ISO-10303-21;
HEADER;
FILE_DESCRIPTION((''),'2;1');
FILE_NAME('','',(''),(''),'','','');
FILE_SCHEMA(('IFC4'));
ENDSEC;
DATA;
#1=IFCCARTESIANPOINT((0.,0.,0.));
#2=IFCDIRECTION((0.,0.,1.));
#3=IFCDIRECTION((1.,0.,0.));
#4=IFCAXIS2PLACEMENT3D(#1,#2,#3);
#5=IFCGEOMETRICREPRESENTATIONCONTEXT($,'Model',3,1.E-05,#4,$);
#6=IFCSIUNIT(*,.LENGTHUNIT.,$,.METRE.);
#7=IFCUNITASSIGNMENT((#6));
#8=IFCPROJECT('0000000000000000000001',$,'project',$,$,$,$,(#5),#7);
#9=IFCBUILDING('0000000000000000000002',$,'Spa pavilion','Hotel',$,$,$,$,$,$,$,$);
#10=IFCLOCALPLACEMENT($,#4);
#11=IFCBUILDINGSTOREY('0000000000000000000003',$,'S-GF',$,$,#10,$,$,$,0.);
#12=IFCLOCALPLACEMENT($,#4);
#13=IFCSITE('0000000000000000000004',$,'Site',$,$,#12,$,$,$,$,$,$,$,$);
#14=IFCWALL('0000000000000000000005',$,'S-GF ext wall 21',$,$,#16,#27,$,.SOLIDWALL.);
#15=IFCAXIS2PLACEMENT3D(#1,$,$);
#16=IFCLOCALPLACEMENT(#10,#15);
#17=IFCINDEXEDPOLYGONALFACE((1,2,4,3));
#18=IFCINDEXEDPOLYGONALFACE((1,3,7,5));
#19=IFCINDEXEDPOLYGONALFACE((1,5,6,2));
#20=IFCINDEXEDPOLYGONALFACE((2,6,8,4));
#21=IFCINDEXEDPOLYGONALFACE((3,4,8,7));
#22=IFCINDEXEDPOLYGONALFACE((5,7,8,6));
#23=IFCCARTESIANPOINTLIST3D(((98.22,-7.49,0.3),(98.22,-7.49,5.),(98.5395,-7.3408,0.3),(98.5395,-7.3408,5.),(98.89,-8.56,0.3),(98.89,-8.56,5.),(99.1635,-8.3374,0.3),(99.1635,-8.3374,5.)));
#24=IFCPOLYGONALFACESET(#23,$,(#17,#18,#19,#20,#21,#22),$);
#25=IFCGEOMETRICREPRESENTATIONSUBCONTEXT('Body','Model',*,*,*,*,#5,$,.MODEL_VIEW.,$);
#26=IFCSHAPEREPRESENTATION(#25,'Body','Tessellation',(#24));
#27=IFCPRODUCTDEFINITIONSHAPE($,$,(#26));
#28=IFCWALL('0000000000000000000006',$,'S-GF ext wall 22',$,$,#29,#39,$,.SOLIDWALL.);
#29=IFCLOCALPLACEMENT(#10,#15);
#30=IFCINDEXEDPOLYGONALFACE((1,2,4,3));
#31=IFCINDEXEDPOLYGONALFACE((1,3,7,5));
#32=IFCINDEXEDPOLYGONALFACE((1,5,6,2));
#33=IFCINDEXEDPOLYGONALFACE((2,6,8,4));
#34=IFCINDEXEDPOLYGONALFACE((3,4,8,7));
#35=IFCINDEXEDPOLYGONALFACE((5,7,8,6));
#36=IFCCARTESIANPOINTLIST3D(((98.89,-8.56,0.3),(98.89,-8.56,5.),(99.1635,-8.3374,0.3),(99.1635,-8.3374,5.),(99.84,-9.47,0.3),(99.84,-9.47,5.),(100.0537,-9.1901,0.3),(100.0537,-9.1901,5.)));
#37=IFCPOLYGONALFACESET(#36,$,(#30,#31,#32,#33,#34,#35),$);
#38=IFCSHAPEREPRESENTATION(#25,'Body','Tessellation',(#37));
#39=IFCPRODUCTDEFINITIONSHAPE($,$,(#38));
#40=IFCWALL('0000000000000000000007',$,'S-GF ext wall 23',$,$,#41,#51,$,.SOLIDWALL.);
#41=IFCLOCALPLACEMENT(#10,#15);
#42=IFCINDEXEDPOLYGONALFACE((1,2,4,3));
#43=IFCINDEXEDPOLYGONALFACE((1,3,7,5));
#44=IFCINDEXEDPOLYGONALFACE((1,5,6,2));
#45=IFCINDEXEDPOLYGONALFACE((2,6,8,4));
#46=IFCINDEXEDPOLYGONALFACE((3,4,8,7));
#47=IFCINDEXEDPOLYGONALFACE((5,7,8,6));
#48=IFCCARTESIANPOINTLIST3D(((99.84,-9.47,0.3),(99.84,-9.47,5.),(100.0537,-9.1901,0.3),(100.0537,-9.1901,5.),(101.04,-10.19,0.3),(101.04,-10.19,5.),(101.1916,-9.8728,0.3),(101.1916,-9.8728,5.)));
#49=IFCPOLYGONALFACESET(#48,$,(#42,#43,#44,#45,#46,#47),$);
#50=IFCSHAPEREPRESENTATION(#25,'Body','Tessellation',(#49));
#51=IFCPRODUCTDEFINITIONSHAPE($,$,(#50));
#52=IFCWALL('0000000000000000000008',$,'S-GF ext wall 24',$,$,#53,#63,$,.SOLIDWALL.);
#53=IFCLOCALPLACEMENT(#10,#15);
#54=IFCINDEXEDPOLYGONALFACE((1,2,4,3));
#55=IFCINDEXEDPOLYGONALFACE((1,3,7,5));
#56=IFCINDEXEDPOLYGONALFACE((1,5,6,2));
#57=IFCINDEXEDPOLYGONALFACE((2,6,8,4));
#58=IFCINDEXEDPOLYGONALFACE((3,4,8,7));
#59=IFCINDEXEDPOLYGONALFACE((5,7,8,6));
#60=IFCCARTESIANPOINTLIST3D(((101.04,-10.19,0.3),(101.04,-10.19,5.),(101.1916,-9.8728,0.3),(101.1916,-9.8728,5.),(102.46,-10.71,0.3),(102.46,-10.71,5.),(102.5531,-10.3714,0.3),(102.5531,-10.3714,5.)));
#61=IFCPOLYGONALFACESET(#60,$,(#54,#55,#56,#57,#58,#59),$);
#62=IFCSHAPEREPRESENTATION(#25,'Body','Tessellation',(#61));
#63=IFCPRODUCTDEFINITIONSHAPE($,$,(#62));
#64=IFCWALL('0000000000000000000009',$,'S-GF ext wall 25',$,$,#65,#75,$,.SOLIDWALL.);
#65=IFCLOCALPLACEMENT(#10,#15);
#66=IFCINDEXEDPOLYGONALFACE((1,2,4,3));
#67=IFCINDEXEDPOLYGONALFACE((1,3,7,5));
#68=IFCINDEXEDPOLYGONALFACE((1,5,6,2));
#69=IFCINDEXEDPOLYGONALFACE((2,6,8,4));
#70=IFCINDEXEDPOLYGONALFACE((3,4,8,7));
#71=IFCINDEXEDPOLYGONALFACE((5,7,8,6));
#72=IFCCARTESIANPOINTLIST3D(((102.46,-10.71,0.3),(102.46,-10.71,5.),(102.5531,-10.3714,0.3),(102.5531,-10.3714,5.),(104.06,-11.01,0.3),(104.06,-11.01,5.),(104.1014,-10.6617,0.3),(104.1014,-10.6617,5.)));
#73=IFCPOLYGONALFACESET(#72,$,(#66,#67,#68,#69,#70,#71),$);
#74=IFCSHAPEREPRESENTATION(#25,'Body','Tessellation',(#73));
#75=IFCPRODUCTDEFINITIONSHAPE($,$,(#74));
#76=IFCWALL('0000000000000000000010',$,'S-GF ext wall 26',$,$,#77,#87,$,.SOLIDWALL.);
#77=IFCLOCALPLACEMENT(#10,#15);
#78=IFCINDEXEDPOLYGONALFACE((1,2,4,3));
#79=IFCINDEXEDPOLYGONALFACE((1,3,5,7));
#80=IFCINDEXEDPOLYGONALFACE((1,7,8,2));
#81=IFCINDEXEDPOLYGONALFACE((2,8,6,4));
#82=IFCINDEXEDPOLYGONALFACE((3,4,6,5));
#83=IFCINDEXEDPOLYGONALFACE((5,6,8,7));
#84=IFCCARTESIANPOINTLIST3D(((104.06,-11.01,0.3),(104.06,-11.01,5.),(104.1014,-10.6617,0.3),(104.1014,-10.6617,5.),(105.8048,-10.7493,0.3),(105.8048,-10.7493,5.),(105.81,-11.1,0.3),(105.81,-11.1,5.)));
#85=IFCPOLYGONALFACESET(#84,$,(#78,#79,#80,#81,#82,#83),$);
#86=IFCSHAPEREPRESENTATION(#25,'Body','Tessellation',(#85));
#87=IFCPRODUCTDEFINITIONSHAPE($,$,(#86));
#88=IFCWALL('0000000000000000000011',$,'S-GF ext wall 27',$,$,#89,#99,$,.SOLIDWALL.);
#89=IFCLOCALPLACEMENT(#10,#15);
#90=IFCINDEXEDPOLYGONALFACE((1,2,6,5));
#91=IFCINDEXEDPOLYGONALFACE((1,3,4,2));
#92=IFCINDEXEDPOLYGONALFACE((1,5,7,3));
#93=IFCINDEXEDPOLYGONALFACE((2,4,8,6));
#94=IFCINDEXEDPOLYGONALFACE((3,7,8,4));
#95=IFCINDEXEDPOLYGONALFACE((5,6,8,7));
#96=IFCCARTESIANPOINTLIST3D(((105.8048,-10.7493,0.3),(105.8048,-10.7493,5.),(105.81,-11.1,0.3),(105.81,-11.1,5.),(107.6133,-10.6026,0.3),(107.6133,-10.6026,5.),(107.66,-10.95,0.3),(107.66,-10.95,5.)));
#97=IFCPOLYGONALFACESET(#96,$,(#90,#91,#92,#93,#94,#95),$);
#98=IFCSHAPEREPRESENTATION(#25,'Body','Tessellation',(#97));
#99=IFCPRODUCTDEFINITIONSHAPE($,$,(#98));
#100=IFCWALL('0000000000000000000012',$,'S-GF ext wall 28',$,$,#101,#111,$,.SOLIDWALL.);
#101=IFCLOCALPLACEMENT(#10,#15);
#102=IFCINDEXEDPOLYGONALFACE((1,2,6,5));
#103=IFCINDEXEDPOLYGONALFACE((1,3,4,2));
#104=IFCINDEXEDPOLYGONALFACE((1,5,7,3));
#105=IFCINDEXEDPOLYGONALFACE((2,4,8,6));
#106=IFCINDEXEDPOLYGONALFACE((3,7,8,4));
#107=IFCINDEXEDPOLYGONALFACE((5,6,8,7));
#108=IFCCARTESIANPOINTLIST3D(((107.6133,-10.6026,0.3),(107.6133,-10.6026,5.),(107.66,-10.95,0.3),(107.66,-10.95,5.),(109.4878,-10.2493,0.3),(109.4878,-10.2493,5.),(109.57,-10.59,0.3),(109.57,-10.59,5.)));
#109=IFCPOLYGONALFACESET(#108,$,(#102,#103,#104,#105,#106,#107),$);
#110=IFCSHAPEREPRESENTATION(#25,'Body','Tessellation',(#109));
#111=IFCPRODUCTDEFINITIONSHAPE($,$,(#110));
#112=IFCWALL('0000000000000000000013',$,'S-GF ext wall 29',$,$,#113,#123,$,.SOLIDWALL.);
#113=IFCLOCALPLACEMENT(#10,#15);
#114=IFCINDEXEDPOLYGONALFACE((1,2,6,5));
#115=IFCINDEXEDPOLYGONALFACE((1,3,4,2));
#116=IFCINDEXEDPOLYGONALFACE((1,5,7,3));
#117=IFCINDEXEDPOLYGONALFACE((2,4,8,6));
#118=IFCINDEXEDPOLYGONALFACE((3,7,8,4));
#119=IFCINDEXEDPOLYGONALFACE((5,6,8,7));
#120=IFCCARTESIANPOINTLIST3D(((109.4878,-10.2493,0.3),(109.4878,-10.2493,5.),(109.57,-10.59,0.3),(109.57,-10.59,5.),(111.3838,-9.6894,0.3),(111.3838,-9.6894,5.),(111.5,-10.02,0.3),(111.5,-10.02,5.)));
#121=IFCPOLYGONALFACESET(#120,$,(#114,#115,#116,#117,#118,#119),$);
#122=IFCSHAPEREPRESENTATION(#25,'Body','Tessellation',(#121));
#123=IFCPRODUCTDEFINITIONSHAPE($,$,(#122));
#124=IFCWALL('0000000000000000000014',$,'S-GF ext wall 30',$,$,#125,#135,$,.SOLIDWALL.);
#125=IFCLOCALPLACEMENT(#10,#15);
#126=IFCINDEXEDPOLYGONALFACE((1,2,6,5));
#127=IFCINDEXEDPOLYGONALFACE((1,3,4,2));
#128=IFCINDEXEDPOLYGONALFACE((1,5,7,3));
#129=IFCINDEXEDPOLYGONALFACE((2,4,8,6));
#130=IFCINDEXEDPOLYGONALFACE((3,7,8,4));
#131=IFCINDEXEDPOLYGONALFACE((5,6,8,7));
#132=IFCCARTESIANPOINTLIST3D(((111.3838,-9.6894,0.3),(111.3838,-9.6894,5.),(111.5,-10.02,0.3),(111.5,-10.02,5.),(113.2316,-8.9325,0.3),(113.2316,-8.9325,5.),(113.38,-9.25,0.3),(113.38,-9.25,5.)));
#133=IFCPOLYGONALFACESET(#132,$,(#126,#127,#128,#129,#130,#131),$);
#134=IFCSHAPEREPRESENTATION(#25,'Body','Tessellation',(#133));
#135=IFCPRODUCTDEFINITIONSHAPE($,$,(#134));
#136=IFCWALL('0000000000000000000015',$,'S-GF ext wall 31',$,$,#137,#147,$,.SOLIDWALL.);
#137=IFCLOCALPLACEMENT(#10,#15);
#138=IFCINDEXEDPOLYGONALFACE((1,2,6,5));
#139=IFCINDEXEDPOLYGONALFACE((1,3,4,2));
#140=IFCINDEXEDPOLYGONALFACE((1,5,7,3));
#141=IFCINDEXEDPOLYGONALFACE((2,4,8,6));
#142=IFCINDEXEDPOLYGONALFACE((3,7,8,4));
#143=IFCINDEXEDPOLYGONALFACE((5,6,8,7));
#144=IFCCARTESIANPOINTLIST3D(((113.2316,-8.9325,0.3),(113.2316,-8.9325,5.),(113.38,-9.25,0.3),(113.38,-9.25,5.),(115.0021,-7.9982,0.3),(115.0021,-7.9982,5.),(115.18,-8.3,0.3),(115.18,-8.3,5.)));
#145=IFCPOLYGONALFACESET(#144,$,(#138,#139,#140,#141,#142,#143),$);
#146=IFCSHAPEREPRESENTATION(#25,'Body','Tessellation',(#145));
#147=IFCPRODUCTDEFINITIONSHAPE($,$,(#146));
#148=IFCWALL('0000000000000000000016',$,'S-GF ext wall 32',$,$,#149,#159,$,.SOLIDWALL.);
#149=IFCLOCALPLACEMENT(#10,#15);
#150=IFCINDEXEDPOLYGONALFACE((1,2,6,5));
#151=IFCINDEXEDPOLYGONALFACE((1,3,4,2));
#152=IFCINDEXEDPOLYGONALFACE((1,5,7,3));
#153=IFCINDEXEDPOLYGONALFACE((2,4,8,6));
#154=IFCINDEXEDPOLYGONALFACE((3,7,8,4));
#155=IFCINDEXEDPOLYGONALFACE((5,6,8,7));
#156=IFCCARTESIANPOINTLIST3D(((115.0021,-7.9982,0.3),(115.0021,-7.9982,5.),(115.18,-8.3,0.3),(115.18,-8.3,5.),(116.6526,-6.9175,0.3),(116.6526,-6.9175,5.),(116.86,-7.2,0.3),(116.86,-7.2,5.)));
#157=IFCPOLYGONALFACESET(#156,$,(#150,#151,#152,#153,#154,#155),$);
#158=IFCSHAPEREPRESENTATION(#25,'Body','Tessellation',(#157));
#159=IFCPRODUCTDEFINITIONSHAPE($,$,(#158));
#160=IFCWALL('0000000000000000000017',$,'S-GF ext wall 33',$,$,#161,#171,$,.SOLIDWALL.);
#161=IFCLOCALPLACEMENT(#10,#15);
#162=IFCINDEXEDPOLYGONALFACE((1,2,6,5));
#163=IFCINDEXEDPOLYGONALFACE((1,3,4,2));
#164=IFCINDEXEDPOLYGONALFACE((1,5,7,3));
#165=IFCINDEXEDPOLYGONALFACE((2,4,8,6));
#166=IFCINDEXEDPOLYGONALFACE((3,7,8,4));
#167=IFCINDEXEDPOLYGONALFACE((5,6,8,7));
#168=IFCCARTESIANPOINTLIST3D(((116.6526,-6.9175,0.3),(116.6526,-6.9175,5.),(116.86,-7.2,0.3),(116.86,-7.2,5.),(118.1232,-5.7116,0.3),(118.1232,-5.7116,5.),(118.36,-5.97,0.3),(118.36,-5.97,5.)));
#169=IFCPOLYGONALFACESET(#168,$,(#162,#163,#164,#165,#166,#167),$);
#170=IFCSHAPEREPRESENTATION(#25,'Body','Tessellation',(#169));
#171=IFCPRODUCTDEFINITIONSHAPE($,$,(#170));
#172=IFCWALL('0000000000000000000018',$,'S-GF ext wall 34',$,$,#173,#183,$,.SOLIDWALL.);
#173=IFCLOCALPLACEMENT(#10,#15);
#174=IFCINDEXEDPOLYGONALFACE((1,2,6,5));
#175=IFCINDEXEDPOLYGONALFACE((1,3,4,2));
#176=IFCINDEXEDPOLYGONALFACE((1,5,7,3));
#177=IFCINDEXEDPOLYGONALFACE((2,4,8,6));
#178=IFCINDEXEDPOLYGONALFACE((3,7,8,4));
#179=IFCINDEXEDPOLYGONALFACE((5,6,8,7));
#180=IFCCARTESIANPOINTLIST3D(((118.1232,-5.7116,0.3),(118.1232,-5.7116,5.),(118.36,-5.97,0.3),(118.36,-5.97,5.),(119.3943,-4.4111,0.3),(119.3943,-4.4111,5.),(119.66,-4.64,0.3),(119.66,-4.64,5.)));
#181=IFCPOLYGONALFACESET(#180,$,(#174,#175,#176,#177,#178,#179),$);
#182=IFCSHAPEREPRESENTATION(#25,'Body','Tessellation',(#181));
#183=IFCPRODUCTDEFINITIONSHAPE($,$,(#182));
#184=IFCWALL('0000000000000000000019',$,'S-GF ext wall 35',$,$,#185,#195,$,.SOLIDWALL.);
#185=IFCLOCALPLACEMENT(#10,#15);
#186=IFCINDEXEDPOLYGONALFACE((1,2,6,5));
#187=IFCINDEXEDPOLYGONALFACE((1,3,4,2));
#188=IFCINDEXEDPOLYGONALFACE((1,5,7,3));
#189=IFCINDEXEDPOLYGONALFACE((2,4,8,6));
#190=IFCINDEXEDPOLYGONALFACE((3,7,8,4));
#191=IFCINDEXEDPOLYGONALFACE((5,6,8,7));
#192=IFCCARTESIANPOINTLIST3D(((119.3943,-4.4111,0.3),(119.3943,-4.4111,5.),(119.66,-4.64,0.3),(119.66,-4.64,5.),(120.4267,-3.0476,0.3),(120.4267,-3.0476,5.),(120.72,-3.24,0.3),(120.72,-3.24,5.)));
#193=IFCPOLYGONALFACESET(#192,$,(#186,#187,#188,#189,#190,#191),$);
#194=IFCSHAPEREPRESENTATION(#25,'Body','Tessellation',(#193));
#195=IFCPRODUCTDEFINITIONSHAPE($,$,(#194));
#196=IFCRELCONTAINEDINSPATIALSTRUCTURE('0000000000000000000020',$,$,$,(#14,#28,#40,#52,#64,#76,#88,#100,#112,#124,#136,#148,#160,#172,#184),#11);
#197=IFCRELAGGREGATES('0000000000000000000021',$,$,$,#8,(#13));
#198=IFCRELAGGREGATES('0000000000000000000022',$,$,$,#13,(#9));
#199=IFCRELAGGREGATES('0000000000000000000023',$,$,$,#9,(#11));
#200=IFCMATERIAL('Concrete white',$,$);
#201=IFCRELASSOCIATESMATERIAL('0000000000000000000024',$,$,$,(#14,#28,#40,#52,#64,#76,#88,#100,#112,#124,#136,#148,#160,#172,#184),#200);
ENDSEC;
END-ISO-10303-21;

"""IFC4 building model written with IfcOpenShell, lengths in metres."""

from ifc_helpers import new_model, si_unit, frame, origin_with_axes, place, context, subcontext, project, spatial, polyline, outline, extrude, material, element, save


model = new_model("IFC4")

# Units and contexts
model_context = context("Model", 3, precision=1e-05, world=origin_with_axes())
body_context = subcontext(model_context, "Body", "Model", "MODEL_VIEW")
ifc_project = project(units=[si_unit("LENGTHUNIT", "METRE")], contexts=[model_context])

# Site, building, storey
site_placement = place(None, origin_with_axes())
site = spatial("IfcSite", under=ifc_project, at=site_placement, Name="Site")
building = spatial("IfcBuilding", under=site, Name="Spa pavilion", Description="Hotel")
storey_placement = place(None, origin_with_axes())
storey = spatial("IfcBuildingStorey", under=building, at=storey_placement, Name="S-GF", Elevation=0.0)

# Walls
ifc_material_1 = material(Name="Concrete white")
wall_1_placement = place(storey_placement, origin_with_axes())
element("IfcWall", 1, at=wall_1_placement, inside=storey, material=ifc_material_1, Name="S-GF ext wall 21", PredefinedType="SOLIDWALL", context=body_context, shape_type="SweptSolid", body=[
    extrude(outline(polyline([(98.22, -7.49), (98.89, -8.56), (99.1635, -8.3374), (98.5395, -7.3408), (98.22, -7.49)])), frame((0.0, 0.0, 0.3), z_axis=(0.0, 0.0, 1.0), x_axis=(1.0, 0.0, 0.0)), (0.0, 0.0, 1.0), 4.7),
])
wall_2_placement = place(storey_placement, origin_with_axes())
element("IfcWall", 2, at=wall_2_placement, inside=storey, material=ifc_material_1, Name="S-GF ext wall 22", PredefinedType="SOLIDWALL", context=body_context, shape_type="SweptSolid", body=[
    extrude(outline(polyline([(98.89, -8.56), (99.84, -9.47), (100.0537, -9.1901), (99.1635, -8.3374), (98.89, -8.56)])), frame((0.0, 0.0, 0.3), z_axis=(0.0, 0.0, 1.0), x_axis=(1.0, 0.0, 0.0)), (0.0, 0.0, 1.0), 4.7),
])
wall_3_placement = place(storey_placement, origin_with_axes())
element("IfcWall", 3, at=wall_3_placement, inside=storey, material=ifc_material_1, Name="S-GF ext wall 23", PredefinedType="SOLIDWALL", context=body_context, shape_type="SweptSolid", body=[
    extrude(outline(polyline([(99.84, -9.47), (101.04, -10.19), (101.1916, -9.8728), (100.0537, -9.1901), (99.84, -9.47)])), frame((0.0, 0.0, 0.3), z_axis=(0.0, 0.0, 1.0), x_axis=(1.0, 0.0, 0.0)), (0.0, 0.0, 1.0), 4.7),
])
wall_4_placement = place(storey_placement, origin_with_axes())
element("IfcWall", 4, at=wall_4_placement, inside=storey, material=ifc_material_1, Name="S-GF ext wall 24", PredefinedType="SOLIDWALL", context=body_context, shape_type="SweptSolid", body=[
    extrude(outline(polyline([(101.04, -10.19), (102.46, -10.71), (102.5531, -10.3714), (101.1916, -9.8728), (101.04, -10.19)])), frame((0.0, 0.0, 0.3), z_axis=(0.0, 0.0, 1.0), x_axis=(1.0, 0.0, 0.0)), (0.0, 0.0, 1.0), 4.7),
])
wall_5_placement = place(storey_placement, origin_with_axes())
element("IfcWall", 5, at=wall_5_placement, inside=storey, material=ifc_material_1, Name="S-GF ext wall 25", PredefinedType="SOLIDWALL", context=body_context, shape_type="SweptSolid", body=[
    extrude(outline(polyline([(102.46, -10.71), (104.06, -11.01), (104.1014, -10.6617), (102.5531, -10.3714), (102.46, -10.71)])), frame((0.0, 0.0, 0.3), z_axis=(0.0, 0.0, 1.0), x_axis=(1.0, 0.0, 0.0)), (0.0, 0.0, 1.0), 4.7),
])
wall_6_placement = place(storey_placement, origin_with_axes())
element("IfcWall", 6, at=wall_6_placement, inside=storey, material=ifc_material_1, Name="S-GF ext wall 26", PredefinedType="SOLIDWALL", context=body_context, shape_type="SweptSolid", body=[
    extrude(outline(polyline([(104.06, -11.01), (105.81, -11.1), (105.8048, -10.7493), (104.1014, -10.6617), (104.06, -11.01)])), frame((0.0, 0.0, 0.3), z_axis=(0.0, 0.0, 1.0), x_axis=(1.0, 0.0, 0.0)), (0.0, 0.0, 1.0), 4.7),
])
wall_7_placement = place(storey_placement, origin_with_axes())
element("IfcWall", 7, at=wall_7_placement, inside=storey, material=ifc_material_1, Name="S-GF ext wall 27", PredefinedType="SOLIDWALL", context=body_context, shape_type="SweptSolid", body=[
    extrude(outline(polyline([(105.81, -11.1), (107.66, -10.95), (107.6133, -10.6026), (105.8048, -10.7493), (105.81, -11.1)])), frame((0.0, 0.0, 0.3), z_axis=(0.0, 0.0, 1.0), x_axis=(1.0, 0.0, 0.0)), (0.0, 0.0, 1.0), 4.7),
])
wall_8_placement = place(storey_placement, origin_with_axes())
element("IfcWall", 8, at=wall_8_placement, inside=storey, material=ifc_material_1, Name="S-GF ext wall 28", PredefinedType="SOLIDWALL", context=body_context, shape_type="SweptSolid", body=[
    extrude(outline(polyline([(107.66, -10.95), (109.57, -10.59), (109.4878, -10.2493), (107.6133, -10.6026), (107.66, -10.95)])), frame((0.0, 0.0, 0.3), z_axis=(0.0, 0.0, 1.0), x_axis=(1.0, 0.0, 0.0)), (0.0, 0.0, 1.0), 4.7),
])
wall_9_placement = place(storey_placement, origin_with_axes())
element("IfcWall", 9, at=wall_9_placement, inside=storey, material=ifc_material_1, Name="S-GF ext wall 29", PredefinedType="SOLIDWALL", context=body_context, shape_type="SweptSolid", body=[
    extrude(outline(polyline([(109.57, -10.59), (111.5, -10.02), (111.3838, -9.6894), (109.4878, -10.2493), (109.57, -10.59)])), frame((0.0, 0.0, 0.3), z_axis=(0.0, 0.0, 1.0), x_axis=(1.0, 0.0, 0.0)), (0.0, 0.0, 1.0), 4.7),
])
wall_10_placement = place(storey_placement, origin_with_axes())
element("IfcWall", 10, at=wall_10_placement, inside=storey, material=ifc_material_1, Name="S-GF ext wall 30", PredefinedType="SOLIDWALL", context=body_context, shape_type="SweptSolid", body=[
    extrude(outline(polyline([(111.5, -10.02), (113.38, -9.25), (113.2316, -8.9325), (111.3838, -9.6894), (111.5, -10.02)])), frame((0.0, 0.0, 0.3), z_axis=(0.0, 0.0, 1.0), x_axis=(1.0, 0.0, 0.0)), (0.0, 0.0, 1.0), 4.7),
])
wall_11_placement = place(storey_placement, origin_with_axes())
element("IfcWall", 11, at=wall_11_placement, inside=storey, material=ifc_material_1, Name="S-GF ext wall 31", PredefinedType="SOLIDWALL", context=body_context, shape_type="SweptSolid", body=[
    extrude(outline(polyline([(113.38, -9.25), (115.18, -8.3), (115.0021, -7.9982), (113.2316, -8.9325), (113.38, -9.25)])), frame((0.0, 0.0, 0.3), z_axis=(0.0, 0.0, 1.0), x_axis=(1.0, 0.0, 0.0)), (0.0, 0.0, 1.0), 4.7),
])
wall_12_placement = place(storey_placement, origin_with_axes())
element("IfcWall", 12, at=wall_12_placement, inside=storey, material=ifc_material_1, Name="S-GF ext wall 32", PredefinedType="SOLIDWALL", context=body_context, shape_type="SweptSolid", body=[
    extrude(outline(polyline([(115.18, -8.3), (116.86, -7.2), (116.6526, -6.9175), (115.0021, -7.9982), (115.18, -8.3)])), frame((0.0, 0.0, 0.3), z_axis=(0.0, 0.0, 1.0), x_axis=(1.0, 0.0, 0.0)), (0.0, 0.0, 1.0), 4.7),
])
wall_13_placement = place(storey_placement, origin_with_axes())
element("IfcWall", 13, at=wall_13_placement, inside=storey, material=ifc_material_1, Name="S-GF ext wall 33", PredefinedType="SOLIDWALL", context=body_context, shape_type="SweptSolid", body=[
    extrude(outline(polyline([(116.86, -7.2), (118.36, -5.97), (118.1232, -5.7116), (116.6526, -6.9175), (116.86, -7.2)])), frame((0.0, 0.0, 0.3), z_axis=(0.0, 0.0, 1.0), x_axis=(1.0, 0.0, 0.0)), (0.0, 0.0, 1.0), 4.7),
])
wall_14_placement = place(storey_placement, origin_with_axes())
element("IfcWall", 14, at=wall_14_placement, inside=storey, material=ifc_material_1, Name="S-GF ext wall 34", PredefinedType="SOLIDWALL", context=body_context, shape_type="SweptSolid", body=[
    extrude(outline(polyline([(118.36, -5.97), (119.66, -4.64), (119.3943, -4.4111), (118.1232, -5.7116), (118.36, -5.97)])), frame((0.0, 0.0, 0.3), z_axis=(0.0, 0.0, 1.0), x_axis=(1.0, 0.0, 0.0)), (0.0, 0.0, 1.0), 4.7),
])
wall_15_placement = place(storey_placement, origin_with_axes())
element("IfcWall", 15, at=wall_15_placement, inside=storey, material=ifc_material_1, Name="S-GF ext wall 35", PredefinedType="SOLIDWALL", context=body_context, shape_type="SweptSolid", body=[
    extrude(outline(polyline([(119.66, -4.64), (120.72, -3.24), (120.4267, -3.0476), (119.3943, -4.4111), (119.66, -4.64)])), frame((0.0, 0.0, 0.3), z_axis=(0.0, 0.0, 1.0), x_axis=(1.0, 0.0, 0.0)), (0.0, 0.0, 1.0), 4.7),
])

save(model, "model.ifc")
